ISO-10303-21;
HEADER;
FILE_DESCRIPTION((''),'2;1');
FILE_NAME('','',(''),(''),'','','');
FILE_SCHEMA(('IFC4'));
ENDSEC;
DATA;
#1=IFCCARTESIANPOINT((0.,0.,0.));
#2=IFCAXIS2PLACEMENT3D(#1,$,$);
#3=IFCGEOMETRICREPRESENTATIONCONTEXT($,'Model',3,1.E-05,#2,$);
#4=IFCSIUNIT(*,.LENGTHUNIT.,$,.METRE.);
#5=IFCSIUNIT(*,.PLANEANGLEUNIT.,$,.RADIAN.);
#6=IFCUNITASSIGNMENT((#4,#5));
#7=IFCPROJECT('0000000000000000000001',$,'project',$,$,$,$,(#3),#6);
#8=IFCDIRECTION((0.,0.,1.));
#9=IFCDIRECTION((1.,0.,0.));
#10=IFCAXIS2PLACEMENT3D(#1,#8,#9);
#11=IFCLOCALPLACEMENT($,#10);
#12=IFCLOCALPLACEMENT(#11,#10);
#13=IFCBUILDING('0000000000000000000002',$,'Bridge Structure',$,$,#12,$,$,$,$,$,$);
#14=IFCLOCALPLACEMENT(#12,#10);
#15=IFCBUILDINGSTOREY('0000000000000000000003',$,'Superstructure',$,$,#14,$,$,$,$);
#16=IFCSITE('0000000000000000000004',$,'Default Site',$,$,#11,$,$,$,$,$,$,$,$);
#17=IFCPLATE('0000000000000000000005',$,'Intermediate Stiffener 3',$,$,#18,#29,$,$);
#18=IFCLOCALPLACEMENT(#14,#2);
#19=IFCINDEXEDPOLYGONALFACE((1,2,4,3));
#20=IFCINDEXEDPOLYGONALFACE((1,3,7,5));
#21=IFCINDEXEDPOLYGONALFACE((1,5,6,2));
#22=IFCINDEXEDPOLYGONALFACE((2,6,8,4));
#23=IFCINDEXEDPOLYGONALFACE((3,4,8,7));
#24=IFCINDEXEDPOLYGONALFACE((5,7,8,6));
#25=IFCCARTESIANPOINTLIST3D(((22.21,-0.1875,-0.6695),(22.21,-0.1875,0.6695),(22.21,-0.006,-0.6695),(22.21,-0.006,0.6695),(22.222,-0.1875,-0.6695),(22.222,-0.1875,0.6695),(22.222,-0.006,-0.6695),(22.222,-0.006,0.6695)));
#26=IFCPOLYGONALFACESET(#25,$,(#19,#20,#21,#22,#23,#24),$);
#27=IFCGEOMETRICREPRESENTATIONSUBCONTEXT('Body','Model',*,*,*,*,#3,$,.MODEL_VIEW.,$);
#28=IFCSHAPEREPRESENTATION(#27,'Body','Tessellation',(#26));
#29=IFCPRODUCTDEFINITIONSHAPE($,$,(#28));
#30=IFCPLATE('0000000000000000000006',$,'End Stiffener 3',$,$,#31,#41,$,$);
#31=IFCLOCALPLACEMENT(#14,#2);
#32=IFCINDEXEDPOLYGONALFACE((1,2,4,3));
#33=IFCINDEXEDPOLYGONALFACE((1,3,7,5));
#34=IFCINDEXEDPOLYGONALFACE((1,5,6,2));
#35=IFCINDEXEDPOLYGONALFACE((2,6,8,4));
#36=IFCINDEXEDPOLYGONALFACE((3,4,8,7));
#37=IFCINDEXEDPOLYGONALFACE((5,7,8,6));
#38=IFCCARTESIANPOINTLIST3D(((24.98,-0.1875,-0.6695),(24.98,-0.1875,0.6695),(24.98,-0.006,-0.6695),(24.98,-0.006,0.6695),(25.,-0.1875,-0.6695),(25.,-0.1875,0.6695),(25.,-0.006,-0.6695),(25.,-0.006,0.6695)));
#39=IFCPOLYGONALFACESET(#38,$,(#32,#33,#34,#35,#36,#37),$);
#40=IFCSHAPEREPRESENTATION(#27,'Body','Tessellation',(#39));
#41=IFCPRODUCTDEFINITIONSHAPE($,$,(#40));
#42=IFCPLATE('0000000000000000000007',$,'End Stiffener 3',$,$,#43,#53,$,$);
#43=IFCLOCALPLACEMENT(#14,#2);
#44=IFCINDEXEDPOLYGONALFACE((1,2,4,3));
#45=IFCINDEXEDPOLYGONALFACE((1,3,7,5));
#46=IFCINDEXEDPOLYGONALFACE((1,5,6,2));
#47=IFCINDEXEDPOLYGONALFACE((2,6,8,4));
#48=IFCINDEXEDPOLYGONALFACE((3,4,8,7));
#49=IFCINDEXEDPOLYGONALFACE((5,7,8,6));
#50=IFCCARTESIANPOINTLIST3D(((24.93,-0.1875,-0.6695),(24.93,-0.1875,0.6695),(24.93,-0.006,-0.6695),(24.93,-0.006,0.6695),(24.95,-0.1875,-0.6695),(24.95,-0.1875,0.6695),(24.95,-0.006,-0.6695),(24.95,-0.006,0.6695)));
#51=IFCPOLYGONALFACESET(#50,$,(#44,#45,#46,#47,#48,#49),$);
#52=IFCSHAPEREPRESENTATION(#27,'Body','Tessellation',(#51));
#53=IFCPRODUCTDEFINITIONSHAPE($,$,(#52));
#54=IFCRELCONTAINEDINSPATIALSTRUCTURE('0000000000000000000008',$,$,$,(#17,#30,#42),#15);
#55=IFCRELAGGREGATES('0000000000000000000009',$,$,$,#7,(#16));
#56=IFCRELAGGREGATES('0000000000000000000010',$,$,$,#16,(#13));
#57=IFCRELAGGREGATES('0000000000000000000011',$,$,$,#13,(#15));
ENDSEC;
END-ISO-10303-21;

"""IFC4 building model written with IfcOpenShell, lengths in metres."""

from ifc_helpers import new_model, si_unit, frame, origin, origin_with_axes, origin_2d_with_axis, place, context, subcontext, project, spatial, rectangle, extrude, element, save


model = new_model("IFC4")

# Units and contexts
model_context = context("Model", 3, precision=1e-05, world=origin())
body_context = subcontext(model_context, "Body", "Model", "MODEL_VIEW")
ifc_project = project(units=[si_unit("LENGTHUNIT", "METRE"), si_unit("PLANEANGLEUNIT", "RADIAN")], contexts=[model_context])

# Site, building, storey
site_placement = place(None, origin_with_axes())
site = spatial("IfcSite", under=ifc_project, at=site_placement, Name="Default Site")
building_placement = place(site_placement, origin_with_axes())
building = spatial("IfcBuilding", under=site, at=building_placement, Name="Bridge Structure")
storey_placement = place(building_placement, origin_with_axes())
storey = spatial("IfcBuildingStorey", under=building, at=storey_placement, Name="Superstructure")

# Plates
plate_placement = place(storey_placement, frame((22.216, -0.0968, -0.6695), z_axis=(0.0, 0.0, 1.0), x_axis=(1.0, 0.0, 0.0)))
element("IfcPlate", 1, at=plate_placement, inside=storey, Name="Intermediate Stiffener 3", context=body_context, shape_type="SweptSolid", body=[
    extrude(rectangle(XDim=0.012, YDim=0.1815, at=origin_2d_with_axis()), origin_with_axes(), (0.0, 0.0, 1.0), 1.339),
])
for number, where, z_axis, x_axis, name in (
    (2, (24.99, -0.0968, -0.6695), (0.0, 0.0, 1.0), (1.0, 0.0, 0.0), "End Stiffener 3"),
    (3, (24.94, -0.0968, -0.6695), (0.0, 0.0, 1.0), (1.0, 0.0, 0.0), "End Stiffener 3"),
):
    element("IfcPlate", number, at=place(storey_placement, frame(where, z_axis=z_axis, x_axis=x_axis)), inside=storey, Name=name, context=body_context, shape_type="SweptSolid", body=[
        extrude(rectangle(XDim=0.02, YDim=0.1815, at=origin_2d_with_axis()), origin_with_axes(), (0.0, 0.0, 1.0), 1.339),
    ])

save(model, "model.ifc")
